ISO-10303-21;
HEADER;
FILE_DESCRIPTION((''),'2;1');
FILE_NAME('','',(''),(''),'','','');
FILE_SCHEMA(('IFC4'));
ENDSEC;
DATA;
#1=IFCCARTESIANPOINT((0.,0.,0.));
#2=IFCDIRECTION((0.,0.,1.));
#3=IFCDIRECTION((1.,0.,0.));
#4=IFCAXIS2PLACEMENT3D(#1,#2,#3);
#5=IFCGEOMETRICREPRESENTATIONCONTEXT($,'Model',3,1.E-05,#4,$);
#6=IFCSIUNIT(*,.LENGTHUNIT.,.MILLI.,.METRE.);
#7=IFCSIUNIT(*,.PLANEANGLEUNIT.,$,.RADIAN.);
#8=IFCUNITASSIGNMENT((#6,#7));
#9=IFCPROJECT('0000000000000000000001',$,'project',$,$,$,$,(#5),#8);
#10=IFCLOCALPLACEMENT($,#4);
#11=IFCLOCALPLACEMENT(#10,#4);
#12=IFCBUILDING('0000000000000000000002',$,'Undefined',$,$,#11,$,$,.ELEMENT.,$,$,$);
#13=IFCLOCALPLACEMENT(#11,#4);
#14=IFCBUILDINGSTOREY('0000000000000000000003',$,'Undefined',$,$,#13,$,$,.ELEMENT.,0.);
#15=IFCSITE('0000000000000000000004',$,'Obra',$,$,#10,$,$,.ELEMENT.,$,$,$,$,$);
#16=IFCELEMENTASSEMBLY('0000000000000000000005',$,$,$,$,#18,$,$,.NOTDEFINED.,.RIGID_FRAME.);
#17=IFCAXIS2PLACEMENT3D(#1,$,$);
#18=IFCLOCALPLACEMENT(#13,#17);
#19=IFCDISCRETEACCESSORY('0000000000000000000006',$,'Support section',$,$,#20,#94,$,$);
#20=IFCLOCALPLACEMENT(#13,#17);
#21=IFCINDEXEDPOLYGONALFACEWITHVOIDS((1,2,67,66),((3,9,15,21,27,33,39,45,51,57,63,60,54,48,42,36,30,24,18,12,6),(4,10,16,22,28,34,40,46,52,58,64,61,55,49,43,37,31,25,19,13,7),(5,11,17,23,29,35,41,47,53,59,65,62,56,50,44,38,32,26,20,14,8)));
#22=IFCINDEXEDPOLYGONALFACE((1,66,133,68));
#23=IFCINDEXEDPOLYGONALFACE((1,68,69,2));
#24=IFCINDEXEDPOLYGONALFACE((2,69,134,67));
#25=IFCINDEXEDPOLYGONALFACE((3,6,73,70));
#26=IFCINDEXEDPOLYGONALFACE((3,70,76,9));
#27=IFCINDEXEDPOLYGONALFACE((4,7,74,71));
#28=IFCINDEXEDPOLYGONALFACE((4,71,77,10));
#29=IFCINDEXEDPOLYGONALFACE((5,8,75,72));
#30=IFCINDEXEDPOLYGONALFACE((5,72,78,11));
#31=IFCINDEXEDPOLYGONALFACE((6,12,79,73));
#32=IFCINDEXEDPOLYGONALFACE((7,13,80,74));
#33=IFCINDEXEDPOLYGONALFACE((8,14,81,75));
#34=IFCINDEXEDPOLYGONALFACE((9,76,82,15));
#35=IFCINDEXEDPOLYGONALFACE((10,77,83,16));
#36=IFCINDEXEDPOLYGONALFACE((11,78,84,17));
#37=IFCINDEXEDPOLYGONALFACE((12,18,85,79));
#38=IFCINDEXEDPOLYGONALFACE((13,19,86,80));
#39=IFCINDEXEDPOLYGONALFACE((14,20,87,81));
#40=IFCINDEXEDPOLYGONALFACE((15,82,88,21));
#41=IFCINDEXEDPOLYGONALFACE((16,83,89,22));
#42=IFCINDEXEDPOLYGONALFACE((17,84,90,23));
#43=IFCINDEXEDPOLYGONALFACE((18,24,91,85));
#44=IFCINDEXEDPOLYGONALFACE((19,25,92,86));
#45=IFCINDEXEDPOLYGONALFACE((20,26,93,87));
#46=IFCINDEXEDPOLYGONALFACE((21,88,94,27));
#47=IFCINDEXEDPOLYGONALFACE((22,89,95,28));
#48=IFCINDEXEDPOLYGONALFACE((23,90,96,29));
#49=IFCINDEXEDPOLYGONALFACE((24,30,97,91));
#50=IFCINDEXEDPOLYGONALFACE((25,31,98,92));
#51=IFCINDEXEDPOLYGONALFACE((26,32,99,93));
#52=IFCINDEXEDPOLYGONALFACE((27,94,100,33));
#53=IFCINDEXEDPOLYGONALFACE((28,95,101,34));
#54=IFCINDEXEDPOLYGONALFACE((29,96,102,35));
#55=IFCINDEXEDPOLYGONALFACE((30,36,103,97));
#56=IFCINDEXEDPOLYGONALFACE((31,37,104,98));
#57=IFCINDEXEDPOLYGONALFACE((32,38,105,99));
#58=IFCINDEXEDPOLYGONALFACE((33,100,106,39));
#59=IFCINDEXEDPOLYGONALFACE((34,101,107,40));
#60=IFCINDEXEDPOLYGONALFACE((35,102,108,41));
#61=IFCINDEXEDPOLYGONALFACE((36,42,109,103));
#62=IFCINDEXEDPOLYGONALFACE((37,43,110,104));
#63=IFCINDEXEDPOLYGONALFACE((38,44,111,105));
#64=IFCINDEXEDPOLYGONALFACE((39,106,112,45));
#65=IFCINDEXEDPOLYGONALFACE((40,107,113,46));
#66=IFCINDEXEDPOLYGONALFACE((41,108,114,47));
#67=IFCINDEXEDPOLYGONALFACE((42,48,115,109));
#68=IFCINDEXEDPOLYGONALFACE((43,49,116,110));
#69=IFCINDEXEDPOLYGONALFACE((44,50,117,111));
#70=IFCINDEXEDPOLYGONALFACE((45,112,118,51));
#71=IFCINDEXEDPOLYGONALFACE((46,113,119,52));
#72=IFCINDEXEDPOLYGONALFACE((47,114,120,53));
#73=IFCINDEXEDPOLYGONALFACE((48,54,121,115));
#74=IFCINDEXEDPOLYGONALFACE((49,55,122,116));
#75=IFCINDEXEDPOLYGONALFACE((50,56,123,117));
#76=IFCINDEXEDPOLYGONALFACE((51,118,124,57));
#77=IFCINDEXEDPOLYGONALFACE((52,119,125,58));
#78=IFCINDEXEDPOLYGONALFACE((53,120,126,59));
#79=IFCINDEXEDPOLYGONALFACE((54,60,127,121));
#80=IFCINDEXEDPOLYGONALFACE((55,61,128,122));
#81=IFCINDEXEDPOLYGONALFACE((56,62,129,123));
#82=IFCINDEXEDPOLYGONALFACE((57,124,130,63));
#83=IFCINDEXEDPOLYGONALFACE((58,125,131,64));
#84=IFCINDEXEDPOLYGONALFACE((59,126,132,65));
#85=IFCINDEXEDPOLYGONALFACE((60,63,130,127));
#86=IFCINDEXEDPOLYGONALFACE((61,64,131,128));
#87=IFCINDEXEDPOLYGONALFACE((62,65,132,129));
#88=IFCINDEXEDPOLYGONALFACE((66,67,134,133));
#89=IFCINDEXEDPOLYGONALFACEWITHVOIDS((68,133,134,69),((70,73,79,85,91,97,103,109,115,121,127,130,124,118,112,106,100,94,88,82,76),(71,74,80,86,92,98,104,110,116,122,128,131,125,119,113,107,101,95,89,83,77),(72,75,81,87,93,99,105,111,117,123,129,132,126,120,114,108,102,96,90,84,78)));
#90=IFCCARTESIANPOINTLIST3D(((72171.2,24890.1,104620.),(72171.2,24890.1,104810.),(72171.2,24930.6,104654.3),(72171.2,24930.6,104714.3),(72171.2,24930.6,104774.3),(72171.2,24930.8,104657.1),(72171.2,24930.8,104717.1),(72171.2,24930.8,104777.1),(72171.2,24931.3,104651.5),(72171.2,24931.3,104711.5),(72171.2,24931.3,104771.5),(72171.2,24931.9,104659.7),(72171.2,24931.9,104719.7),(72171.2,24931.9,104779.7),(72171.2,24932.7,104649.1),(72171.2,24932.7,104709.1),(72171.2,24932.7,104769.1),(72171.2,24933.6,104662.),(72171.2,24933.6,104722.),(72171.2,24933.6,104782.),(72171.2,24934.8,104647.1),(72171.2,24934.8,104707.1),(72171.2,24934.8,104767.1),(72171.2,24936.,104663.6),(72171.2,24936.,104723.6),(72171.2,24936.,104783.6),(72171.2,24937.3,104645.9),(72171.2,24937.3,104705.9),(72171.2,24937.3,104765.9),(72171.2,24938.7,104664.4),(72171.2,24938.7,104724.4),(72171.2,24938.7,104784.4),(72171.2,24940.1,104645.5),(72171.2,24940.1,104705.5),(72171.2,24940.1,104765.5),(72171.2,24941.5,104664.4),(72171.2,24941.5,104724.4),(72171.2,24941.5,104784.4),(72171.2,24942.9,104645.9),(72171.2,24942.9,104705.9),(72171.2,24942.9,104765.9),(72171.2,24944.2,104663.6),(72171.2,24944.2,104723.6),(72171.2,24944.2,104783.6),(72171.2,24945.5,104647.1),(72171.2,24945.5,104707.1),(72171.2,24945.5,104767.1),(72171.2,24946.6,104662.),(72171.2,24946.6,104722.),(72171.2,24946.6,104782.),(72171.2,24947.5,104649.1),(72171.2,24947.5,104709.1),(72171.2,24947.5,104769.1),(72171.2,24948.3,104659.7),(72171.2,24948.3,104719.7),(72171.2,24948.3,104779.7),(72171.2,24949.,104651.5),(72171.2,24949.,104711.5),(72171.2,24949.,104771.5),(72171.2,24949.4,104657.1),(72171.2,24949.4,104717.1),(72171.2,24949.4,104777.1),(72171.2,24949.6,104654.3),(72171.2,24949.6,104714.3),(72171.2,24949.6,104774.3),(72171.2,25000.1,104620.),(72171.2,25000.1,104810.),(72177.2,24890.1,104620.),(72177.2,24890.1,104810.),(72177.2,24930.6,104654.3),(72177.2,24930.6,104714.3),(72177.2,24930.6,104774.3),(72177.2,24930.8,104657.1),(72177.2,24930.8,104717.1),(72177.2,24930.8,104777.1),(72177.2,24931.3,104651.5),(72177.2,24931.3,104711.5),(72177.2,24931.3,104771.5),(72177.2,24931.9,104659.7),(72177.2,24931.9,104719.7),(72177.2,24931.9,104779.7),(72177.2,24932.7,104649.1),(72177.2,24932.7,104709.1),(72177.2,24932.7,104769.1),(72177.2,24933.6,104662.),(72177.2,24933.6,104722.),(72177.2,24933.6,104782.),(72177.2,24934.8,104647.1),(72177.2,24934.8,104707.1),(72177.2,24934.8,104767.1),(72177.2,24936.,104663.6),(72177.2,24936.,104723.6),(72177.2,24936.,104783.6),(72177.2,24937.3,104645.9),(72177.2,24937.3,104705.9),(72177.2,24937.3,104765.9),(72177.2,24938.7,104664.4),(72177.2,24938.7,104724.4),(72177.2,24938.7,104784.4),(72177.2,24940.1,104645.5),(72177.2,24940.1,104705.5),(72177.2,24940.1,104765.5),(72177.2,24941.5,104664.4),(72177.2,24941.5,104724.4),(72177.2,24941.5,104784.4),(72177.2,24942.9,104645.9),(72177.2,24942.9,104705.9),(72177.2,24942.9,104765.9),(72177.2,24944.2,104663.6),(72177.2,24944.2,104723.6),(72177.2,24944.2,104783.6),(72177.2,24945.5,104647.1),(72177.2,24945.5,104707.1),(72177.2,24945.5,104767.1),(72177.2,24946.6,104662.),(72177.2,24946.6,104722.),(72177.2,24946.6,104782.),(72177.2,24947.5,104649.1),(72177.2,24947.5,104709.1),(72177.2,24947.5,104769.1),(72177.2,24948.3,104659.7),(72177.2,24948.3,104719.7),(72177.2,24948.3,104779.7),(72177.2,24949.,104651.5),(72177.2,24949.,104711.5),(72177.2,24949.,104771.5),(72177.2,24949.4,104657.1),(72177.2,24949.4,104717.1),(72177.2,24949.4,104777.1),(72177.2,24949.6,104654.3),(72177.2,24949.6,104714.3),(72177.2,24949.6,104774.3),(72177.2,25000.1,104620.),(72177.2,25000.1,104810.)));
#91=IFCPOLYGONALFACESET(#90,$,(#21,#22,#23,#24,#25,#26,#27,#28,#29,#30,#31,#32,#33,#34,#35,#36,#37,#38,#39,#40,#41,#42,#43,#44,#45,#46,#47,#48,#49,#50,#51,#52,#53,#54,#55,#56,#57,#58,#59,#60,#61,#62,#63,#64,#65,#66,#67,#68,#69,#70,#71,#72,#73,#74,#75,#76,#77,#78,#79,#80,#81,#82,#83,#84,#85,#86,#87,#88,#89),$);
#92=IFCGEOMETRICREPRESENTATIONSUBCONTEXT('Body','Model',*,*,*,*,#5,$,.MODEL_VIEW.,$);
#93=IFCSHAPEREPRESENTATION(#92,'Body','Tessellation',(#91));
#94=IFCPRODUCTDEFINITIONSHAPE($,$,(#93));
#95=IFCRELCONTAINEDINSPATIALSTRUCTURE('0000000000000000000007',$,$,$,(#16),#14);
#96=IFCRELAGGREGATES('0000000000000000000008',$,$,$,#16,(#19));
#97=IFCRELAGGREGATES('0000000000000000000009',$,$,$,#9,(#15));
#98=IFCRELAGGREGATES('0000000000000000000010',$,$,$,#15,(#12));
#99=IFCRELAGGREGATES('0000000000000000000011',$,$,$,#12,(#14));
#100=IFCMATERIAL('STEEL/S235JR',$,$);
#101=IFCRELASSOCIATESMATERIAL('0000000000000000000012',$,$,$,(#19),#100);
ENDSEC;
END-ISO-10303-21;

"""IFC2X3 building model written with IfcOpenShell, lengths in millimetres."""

from ifc_helpers import new_model, si_unit, frame, origin_with_axes, origin_2d_with_axis, place, context, subcontext, project, spatial, rectangle, circle, extrude, source, transform, mapped, material, element, aggregate, save


model = new_model("IFC2X3")

# Units and contexts
model_context = context("Model", 3, precision=1e-05, world=origin_with_axes())
body_context = subcontext(model_context, "Body", "Model", "MODEL_VIEW")
ifc_project = project(units=[si_unit("LENGTHUNIT", "METRE", prefix="MILLI"), si_unit("PLANEANGLEUNIT", "RADIAN")], contexts=[model_context])

# Site, building, storey
site_placement = place(None, origin_with_axes())
site = spatial("IfcSite", under=ifc_project, at=site_placement, Name="Obra", CompositionType="ELEMENT")
building_placement = place(site_placement, origin_with_axes())
building = spatial("IfcBuilding", under=site, at=building_placement, Name="Undefined", CompositionType="ELEMENT")
storey_placement = place(building_placement, origin_with_axes())
storey = spatial("IfcBuildingStorey", under=building, at=storey_placement, Name="Undefined", CompositionType="ELEMENT", Elevation=0.0)

# Shared definitions
ifc_material = material(Name="STEEL/S235JR")

# Shared definitions
shared_shape_1 = source(origin_with_axes(), body_context, "Body", "SweptSolid", [
    extrude(circle(Radius=9.5, at=origin_2d_with_axis()), frame((0.0, -9.2, 0.0), z_axis=(0.0, 1.0, 0.0), x_axis=(1.0, 0.0, 0.0)), (0.0, 0.0, 1.0), 6.2),
])

# Element assembly, discrete accessory, opening
assembly_1_placement = place(storey_placement, origin_with_axes())
assembly_1 = element("IfcElementAssembly", 1, at=assembly_1_placement, inside=storey, AssemblyPlace="NOTDEFINED", PredefinedType="RIGID_FRAME")
discrete_accessory_1_placement = place(assembly_1_placement, frame((72174.2, 24945.1, 104620.0), z_axis=(0.0, 0.0, 1.0), x_axis=(-0.000002, 1.0, 0.0)))
discrete_accessory_1 = element("IfcDiscreteAccessory", 2, at=discrete_accessory_1_placement, material=ifc_material, Name="Support section", context=body_context, shape_type="SweptSolid", body=[
    extrude(rectangle(XDim=6.0, YDim=110.0, at=origin_2d_with_axis()), frame((0.0, 0.0, 190.0), z_axis=(0.0, 0.0, -1.0), x_axis=(0.0, 1.0, 0.0)), (0.0, 0.0, 1.0), 190.0),
])
opening_1_placement = place(assembly_1_placement, frame((72180.3, 24990.1, 104835.0), z_axis=(0.000002, -1.0, 0.0), x_axis=(0.0, 0.0, -1.0)))
element("IfcOpeningElement", 3, at=opening_1_placement, cuts=discrete_accessory_1, ObjectType="Opening", context=body_context, shape_type="MappedRepresentation", body=[
    mapped(shared_shape_1, transform((60.0, 0.0, 50.0))),
    mapped(shared_shape_1, transform((120.0, 0.0, 50.0))),
    mapped(shared_shape_1, transform((180.0, 0.0, 50.0))),
])
aggregate(assembly_1, [discrete_accessory_1])

save(model, "model.ifc")
